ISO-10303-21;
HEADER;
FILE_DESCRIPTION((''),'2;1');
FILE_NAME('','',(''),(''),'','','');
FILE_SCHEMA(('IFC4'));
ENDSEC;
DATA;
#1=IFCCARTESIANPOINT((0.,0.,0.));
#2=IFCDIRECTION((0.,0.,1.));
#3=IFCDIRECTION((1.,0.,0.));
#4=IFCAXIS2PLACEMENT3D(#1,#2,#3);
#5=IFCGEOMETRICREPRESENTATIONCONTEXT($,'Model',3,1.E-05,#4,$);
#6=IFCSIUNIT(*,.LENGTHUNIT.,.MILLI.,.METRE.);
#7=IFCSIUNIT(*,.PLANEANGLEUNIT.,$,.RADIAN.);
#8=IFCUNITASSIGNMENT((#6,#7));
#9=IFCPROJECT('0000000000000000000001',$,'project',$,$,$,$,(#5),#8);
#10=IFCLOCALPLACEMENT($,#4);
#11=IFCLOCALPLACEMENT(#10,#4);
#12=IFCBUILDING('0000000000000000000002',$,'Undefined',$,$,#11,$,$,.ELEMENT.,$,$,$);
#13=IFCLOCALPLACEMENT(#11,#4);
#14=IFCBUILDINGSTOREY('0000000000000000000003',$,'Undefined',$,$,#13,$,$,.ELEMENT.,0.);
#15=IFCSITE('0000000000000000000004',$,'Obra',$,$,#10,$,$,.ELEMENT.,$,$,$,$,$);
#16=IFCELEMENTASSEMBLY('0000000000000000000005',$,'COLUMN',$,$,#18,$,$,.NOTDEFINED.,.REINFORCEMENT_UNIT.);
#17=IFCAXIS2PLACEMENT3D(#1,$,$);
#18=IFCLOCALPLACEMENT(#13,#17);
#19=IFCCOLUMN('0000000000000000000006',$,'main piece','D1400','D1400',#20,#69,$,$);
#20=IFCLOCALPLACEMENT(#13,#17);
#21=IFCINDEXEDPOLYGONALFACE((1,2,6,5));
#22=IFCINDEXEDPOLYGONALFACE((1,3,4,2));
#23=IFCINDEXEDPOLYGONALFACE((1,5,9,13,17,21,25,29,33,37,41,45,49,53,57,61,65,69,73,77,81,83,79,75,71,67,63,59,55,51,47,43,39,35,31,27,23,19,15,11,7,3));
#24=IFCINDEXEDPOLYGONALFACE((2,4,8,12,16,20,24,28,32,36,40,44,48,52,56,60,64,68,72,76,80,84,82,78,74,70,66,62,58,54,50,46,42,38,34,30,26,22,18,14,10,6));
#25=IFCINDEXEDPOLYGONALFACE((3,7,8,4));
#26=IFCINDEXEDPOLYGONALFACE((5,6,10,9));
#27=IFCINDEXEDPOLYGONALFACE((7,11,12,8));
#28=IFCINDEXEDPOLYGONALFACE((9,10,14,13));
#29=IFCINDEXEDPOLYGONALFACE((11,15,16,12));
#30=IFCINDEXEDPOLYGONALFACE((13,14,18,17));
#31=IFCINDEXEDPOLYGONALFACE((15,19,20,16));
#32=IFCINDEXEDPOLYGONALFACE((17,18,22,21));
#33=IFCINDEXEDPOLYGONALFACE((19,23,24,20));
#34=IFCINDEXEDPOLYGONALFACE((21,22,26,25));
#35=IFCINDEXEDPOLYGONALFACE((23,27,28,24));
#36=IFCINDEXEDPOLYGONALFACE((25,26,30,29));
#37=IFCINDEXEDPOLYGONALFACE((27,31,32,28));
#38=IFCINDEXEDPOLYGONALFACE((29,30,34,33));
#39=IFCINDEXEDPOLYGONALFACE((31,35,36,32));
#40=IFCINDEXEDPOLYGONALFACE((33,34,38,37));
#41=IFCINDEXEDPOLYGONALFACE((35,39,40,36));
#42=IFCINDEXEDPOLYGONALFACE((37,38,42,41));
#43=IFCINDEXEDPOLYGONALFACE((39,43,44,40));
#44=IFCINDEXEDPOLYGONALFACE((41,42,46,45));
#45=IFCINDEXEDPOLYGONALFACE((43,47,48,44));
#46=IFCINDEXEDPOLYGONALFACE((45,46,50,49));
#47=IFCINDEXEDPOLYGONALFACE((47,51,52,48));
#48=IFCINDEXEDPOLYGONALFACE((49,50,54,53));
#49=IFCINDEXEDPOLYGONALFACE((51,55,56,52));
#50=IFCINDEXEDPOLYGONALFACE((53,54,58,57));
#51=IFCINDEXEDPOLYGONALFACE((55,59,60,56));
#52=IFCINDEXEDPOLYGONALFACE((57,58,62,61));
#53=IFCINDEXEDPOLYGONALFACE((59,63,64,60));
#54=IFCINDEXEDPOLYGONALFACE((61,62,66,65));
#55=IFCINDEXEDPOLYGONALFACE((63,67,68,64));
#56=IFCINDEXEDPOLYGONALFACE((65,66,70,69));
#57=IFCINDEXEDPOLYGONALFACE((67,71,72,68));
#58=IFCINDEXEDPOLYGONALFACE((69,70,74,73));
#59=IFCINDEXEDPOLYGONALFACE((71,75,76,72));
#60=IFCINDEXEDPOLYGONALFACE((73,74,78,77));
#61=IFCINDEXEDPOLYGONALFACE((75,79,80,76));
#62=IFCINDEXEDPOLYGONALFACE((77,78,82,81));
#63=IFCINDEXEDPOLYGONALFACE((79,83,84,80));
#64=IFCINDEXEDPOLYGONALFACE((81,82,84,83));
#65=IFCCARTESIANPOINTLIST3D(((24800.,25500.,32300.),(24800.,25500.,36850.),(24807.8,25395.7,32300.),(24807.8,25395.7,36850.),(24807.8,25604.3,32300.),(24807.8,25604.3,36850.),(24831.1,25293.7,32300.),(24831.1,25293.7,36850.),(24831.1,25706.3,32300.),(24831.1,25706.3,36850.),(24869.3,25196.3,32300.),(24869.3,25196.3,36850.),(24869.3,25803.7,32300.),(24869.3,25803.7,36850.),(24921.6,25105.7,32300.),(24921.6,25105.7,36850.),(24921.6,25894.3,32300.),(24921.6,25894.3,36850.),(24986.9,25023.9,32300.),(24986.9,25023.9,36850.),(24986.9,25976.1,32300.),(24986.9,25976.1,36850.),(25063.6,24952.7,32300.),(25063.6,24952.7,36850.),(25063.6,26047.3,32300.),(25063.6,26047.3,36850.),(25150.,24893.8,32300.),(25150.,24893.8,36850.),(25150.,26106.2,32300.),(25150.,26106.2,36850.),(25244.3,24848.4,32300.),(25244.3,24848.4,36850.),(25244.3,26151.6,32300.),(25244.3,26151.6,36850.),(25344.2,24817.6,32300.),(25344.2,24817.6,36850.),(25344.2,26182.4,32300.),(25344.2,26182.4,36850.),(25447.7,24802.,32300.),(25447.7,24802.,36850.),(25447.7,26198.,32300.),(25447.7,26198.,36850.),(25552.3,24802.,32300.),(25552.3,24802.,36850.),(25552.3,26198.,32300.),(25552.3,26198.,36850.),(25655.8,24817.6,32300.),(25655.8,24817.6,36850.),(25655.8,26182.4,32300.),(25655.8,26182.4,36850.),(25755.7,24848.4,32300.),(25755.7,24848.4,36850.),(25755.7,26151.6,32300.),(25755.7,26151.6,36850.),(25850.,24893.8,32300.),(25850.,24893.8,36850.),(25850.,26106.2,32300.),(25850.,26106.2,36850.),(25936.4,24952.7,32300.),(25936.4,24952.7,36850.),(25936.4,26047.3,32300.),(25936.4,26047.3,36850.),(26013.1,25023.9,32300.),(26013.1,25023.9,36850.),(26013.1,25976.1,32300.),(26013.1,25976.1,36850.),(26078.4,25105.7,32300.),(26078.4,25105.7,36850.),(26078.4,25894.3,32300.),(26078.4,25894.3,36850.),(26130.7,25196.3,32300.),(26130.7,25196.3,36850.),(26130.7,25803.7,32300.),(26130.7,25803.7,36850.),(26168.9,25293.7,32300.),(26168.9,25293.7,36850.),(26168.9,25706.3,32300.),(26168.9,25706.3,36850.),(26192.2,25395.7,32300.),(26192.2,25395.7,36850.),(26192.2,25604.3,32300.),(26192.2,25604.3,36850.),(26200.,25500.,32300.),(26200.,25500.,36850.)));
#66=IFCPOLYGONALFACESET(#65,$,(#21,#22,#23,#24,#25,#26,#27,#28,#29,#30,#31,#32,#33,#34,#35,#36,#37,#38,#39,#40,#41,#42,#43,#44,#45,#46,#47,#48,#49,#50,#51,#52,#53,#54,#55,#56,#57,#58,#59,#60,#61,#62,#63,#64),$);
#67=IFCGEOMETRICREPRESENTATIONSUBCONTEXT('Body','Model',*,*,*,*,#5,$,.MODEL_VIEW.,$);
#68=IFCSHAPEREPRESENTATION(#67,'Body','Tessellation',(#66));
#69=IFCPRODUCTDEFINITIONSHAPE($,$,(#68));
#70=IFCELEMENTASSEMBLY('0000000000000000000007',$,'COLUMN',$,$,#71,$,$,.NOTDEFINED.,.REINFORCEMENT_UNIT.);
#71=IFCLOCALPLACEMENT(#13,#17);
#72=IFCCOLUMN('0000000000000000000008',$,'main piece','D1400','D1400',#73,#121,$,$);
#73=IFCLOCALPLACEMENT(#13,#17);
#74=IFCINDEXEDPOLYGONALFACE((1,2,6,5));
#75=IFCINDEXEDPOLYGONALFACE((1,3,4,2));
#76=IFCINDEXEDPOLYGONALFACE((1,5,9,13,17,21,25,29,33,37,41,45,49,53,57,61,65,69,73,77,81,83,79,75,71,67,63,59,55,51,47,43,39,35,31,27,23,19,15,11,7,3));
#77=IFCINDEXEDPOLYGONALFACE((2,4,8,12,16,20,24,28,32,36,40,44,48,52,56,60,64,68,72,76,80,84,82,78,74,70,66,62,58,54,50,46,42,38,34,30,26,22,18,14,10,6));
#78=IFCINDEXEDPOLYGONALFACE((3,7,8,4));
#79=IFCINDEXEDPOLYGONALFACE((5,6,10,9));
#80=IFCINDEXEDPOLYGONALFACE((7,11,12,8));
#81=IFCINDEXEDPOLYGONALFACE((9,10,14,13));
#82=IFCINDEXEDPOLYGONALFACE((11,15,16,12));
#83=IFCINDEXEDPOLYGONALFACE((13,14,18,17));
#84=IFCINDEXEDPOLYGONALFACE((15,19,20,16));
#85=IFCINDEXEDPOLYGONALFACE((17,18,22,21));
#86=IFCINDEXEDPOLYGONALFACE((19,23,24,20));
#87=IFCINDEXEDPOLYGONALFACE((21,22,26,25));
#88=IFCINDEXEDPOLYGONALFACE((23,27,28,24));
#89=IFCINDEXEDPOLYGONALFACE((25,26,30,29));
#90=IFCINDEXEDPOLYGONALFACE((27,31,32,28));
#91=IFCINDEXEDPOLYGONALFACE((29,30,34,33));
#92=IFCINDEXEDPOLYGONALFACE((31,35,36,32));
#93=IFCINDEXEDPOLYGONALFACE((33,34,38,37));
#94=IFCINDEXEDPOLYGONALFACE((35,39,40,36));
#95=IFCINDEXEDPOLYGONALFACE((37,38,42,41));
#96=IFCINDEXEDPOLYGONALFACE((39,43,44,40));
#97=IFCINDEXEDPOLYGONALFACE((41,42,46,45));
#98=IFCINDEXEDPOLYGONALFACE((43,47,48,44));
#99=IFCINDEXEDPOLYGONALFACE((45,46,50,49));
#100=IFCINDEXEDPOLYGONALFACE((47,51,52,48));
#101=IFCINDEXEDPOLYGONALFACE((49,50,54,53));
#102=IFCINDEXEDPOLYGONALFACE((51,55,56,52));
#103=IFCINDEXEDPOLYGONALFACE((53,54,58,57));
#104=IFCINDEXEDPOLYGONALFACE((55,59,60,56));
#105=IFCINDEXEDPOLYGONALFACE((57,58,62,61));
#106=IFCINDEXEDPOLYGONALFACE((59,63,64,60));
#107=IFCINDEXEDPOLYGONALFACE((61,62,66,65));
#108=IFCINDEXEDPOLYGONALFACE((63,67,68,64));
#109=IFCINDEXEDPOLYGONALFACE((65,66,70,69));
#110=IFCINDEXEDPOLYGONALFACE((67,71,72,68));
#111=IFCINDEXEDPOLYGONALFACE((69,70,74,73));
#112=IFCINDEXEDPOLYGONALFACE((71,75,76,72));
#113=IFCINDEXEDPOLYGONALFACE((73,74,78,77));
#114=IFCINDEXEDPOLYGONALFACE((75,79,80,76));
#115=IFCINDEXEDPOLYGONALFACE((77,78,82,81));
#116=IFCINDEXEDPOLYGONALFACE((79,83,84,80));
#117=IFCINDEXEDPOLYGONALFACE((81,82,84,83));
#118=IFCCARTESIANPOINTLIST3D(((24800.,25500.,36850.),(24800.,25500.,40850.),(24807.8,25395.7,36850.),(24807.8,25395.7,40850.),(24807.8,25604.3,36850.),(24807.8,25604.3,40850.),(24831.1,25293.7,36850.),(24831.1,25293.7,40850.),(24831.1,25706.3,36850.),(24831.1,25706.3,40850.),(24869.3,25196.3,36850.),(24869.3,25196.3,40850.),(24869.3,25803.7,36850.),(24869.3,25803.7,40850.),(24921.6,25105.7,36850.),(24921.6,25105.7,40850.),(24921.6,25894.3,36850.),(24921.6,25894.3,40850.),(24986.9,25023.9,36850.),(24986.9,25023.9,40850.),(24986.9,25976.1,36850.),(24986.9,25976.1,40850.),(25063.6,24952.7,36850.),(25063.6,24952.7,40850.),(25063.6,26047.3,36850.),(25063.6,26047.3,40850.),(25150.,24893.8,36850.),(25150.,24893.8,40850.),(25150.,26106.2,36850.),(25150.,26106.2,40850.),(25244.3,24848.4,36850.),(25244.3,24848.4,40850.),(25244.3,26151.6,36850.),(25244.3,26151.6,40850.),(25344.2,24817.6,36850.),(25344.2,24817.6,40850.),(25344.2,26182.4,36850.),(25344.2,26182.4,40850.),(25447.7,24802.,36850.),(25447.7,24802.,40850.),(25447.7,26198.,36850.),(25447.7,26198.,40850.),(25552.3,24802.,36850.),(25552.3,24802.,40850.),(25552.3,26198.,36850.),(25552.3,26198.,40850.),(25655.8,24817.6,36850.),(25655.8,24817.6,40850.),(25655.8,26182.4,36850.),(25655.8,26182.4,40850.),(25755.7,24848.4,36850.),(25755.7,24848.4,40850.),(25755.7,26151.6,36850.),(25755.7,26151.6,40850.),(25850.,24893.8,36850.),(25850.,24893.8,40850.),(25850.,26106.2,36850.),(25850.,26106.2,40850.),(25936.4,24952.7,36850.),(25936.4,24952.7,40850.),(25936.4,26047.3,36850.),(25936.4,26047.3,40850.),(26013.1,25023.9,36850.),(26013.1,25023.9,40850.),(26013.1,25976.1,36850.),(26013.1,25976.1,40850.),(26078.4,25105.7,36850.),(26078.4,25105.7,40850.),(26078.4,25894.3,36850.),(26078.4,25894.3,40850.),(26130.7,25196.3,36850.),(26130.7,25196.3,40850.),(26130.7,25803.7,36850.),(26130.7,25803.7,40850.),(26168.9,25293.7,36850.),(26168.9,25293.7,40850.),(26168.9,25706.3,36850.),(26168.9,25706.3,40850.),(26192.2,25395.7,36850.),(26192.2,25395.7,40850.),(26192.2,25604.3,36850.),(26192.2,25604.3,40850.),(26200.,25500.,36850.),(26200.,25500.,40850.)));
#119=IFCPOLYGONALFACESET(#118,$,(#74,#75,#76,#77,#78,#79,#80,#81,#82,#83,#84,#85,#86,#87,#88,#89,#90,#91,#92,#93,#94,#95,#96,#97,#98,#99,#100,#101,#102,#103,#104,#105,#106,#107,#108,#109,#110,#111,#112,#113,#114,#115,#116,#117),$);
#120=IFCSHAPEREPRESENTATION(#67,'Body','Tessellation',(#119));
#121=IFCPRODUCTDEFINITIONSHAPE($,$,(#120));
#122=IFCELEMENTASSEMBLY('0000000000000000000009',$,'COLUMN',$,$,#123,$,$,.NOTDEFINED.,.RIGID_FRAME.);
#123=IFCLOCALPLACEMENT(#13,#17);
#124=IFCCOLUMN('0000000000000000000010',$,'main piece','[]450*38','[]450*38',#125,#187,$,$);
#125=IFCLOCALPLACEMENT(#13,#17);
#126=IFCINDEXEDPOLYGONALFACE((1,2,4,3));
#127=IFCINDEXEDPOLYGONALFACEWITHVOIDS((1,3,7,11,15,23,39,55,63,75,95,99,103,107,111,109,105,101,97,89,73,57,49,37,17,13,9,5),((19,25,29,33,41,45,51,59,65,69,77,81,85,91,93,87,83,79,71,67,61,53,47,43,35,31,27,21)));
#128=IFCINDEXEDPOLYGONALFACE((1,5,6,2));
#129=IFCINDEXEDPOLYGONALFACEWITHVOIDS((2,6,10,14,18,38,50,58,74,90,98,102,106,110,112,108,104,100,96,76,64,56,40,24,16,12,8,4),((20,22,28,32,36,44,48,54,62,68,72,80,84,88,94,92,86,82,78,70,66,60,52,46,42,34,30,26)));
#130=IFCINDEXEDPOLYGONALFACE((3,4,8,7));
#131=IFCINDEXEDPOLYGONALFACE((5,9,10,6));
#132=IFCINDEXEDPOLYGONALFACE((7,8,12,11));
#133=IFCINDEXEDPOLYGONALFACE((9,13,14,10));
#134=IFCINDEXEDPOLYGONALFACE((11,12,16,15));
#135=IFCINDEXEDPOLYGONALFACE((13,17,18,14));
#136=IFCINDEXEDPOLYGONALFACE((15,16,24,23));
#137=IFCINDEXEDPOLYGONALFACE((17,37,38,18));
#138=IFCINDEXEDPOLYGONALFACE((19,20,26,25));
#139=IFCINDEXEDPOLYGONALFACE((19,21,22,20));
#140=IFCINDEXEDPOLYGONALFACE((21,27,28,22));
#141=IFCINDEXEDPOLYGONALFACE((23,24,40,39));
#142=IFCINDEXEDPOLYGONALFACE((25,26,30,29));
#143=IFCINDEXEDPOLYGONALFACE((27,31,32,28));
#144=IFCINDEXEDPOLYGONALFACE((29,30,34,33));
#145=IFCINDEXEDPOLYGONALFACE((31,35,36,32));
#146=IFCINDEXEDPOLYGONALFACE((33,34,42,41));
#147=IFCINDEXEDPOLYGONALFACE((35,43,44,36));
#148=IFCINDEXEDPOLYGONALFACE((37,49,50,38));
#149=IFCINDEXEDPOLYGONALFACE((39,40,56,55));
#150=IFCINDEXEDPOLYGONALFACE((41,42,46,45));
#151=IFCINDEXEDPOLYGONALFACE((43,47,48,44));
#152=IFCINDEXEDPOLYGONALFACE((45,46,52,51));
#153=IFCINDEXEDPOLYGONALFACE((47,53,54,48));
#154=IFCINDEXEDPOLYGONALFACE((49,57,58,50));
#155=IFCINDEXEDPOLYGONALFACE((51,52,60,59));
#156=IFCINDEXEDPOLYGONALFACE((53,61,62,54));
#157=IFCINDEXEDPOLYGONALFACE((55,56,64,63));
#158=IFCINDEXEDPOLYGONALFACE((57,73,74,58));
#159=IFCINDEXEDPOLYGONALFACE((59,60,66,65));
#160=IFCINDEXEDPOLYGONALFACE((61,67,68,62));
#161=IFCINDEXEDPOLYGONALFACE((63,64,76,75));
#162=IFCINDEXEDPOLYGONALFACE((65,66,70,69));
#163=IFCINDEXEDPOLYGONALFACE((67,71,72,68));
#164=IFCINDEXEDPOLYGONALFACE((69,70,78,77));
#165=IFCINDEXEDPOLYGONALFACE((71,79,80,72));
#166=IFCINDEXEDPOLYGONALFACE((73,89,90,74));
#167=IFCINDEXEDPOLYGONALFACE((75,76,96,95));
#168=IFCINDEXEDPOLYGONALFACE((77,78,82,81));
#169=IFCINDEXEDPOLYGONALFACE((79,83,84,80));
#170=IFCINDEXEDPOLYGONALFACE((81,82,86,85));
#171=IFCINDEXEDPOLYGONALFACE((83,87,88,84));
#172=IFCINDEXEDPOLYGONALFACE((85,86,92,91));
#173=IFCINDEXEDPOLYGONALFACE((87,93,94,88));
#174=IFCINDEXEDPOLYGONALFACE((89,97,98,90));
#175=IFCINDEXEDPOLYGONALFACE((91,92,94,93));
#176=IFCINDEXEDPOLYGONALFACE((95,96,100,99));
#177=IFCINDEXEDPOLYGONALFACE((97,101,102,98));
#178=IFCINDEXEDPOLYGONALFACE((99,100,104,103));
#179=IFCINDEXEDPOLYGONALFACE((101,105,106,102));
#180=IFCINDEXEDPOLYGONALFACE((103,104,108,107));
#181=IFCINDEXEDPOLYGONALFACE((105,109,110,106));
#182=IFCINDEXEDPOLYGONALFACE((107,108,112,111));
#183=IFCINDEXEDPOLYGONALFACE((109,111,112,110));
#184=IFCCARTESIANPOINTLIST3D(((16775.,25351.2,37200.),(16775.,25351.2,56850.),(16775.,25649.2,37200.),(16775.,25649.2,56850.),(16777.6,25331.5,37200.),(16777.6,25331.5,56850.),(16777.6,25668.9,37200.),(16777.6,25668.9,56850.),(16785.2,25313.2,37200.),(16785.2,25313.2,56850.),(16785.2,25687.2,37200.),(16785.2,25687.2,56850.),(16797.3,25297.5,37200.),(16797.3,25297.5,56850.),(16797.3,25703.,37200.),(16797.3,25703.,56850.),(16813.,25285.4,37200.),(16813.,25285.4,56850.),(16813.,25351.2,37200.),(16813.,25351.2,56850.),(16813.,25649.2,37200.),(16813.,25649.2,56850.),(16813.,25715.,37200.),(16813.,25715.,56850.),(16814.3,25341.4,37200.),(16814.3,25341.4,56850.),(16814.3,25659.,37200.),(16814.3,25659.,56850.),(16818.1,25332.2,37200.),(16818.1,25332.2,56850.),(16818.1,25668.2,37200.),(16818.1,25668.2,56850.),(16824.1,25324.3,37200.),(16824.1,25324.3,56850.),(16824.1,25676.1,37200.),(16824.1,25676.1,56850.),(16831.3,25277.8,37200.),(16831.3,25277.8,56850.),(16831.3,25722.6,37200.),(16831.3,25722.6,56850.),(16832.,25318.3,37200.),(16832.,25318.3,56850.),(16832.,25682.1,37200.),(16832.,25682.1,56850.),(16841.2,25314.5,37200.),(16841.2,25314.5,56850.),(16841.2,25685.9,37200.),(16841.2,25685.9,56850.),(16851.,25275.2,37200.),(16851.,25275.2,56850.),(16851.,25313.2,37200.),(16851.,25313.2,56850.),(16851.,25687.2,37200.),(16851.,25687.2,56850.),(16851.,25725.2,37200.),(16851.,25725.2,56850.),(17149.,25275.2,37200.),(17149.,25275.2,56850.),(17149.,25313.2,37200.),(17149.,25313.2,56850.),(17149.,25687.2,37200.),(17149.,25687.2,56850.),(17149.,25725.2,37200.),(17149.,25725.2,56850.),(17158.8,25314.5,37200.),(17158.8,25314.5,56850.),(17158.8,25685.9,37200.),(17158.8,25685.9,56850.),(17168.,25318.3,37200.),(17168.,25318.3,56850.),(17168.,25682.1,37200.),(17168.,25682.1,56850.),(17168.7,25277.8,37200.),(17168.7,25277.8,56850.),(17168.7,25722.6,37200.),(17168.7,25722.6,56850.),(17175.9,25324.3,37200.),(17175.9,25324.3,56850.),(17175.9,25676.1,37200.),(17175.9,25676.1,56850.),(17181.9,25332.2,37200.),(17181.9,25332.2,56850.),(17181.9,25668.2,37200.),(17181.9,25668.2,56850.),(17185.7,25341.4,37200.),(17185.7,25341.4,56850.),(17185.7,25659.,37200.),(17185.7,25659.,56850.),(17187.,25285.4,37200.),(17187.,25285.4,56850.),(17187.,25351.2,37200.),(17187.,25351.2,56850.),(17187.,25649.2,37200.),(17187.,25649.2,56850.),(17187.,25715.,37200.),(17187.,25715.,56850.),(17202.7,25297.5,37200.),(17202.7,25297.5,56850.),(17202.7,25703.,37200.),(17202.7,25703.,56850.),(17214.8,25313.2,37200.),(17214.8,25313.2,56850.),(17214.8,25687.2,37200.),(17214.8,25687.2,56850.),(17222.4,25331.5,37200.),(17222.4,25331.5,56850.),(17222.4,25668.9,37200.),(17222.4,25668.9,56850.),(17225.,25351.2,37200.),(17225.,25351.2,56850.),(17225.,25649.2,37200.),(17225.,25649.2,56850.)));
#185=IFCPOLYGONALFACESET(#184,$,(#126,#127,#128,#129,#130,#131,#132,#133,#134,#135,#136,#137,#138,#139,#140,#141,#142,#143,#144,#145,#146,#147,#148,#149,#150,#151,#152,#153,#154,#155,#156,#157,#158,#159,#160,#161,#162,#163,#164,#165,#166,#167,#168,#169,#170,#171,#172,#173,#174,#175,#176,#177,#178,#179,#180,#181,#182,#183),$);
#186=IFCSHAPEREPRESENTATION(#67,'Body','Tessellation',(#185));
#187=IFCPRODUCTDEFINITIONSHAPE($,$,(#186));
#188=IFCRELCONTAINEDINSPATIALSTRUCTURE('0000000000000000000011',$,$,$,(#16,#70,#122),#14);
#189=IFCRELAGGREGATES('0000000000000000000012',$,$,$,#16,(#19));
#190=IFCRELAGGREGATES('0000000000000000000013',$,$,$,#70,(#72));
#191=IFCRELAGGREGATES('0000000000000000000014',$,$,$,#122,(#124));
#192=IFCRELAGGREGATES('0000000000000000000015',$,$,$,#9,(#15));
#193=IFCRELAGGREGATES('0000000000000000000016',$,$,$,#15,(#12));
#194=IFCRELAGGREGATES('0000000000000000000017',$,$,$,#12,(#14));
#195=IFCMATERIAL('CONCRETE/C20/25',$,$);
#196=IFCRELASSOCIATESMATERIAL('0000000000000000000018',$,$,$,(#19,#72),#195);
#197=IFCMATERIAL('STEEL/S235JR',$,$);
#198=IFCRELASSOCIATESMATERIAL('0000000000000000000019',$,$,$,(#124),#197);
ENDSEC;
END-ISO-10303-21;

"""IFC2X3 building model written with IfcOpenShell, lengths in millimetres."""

from ifc_helpers import new_model, si_unit, frame, origin_with_axes, origin_2d_with_axis, place, context, subcontext, project, spatial, hollow_rectangle, circle, extrude, material, element, aggregate, save


model = new_model("IFC2X3")

# Units and contexts
model_context = context("Model", 3, precision=1e-05, world=origin_with_axes())
body_context = subcontext(model_context, "Body", "Model", "MODEL_VIEW")
ifc_project = project(units=[si_unit("LENGTHUNIT", "METRE", prefix="MILLI"), si_unit("PLANEANGLEUNIT", "RADIAN")], contexts=[model_context])

# Site, building, storey
site_placement = place(None, origin_with_axes())
site = spatial("IfcSite", under=ifc_project, at=site_placement, Name="Obra", CompositionType="ELEMENT")
building_placement = place(site_placement, origin_with_axes())
building = spatial("IfcBuilding", under=site, at=building_placement, Name="Undefined", CompositionType="ELEMENT")
storey_placement = place(building_placement, origin_with_axes())
storey = spatial("IfcBuildingStorey", under=building, at=storey_placement, Name="Undefined", CompositionType="ELEMENT", Elevation=0.0)

# Element assemblies, columns
assembly_1_placement = place(storey_placement, origin_with_axes())
assembly_1 = element("IfcElementAssembly", 1, at=assembly_1_placement, inside=storey, Name="COLUMN", AssemblyPlace="NOTDEFINED", PredefinedType="REINFORCEMENT_UNIT")
ifc_material_1 = material(Name="CONCRETE/C20/25")
column_1_placement = place(assembly_1_placement, frame((25500.0, 25500.0, 32300.0), z_axis=(0.0, 0.0, 1.0), x_axis=(0.0, 1.0, 0.0)))
column_1 = element("IfcColumn", 2, at=column_1_placement, material=ifc_material_1, Name="main piece", Description="D1400", ObjectType="D1400", context=body_context, shape_type="SweptSolid", body=[
    extrude(circle(Radius=700.0, at=origin_2d_with_axis()), frame((0.0, 0.0, 4550.0), z_axis=(0.0, 0.0, -1.0), x_axis=(0.0, 1.0, 0.0)), (0.0, 0.0, 1.0), 4550.0),
])
aggregate(assembly_1, [column_1])
assembly_2_placement = place(storey_placement, origin_with_axes())
assembly_2 = element("IfcElementAssembly", 3, at=assembly_2_placement, inside=storey, Name="COLUMN", AssemblyPlace="NOTDEFINED", PredefinedType="REINFORCEMENT_UNIT")
column_2_placement = place(assembly_2_placement, frame((25500.0, 25500.0, 36850.0), z_axis=(0.0, 0.0, 1.0), x_axis=(0.0, 1.0, 0.0)))
column_2 = element("IfcColumn", 4, at=column_2_placement, material=ifc_material_1, Name="main piece", Description="D1400", ObjectType="D1400", context=body_context, shape_type="SweptSolid", body=[
    extrude(circle(Radius=700.0, at=origin_2d_with_axis()), frame((0.0, 0.0, 4000.0), z_axis=(0.0, 0.0, -1.0), x_axis=(0.0, 1.0, 0.0)), (0.0, 0.0, 1.0), 4000.0),
])
aggregate(assembly_2, [column_2])
assembly_3_placement = place(storey_placement, origin_with_axes())
assembly_3 = element("IfcElementAssembly", 5, at=assembly_3_placement, inside=storey, Name="COLUMN", AssemblyPlace="NOTDEFINED", PredefinedType="RIGID_FRAME")
ifc_material_2 = material(Name="STEEL/S235JR")
column_3_placement = place(assembly_3_placement, frame((17000.0, 25500.2, 37200.0), z_axis=(0.0, 0.0, 1.0), x_axis=(0.0, 1.0, 0.0)))
column_3 = element("IfcColumn", 6, at=column_3_placement, material=ifc_material_2, Name="main piece", Description="[]450*38", ObjectType="[]450*38", context=body_context, shape_type="SweptSolid", body=[
    extrude(hollow_rectangle(XDim=450.0, YDim=450.0, WallThickness=38.0, InnerFilletRadius=38.0, OuterFilletRadius=76.0, at=origin_2d_with_axis()), frame((0.0, 0.0, 19650.0), z_axis=(0.0, 0.0, -1.0), x_axis=(0.0, 1.0, 0.0)), (0.0, 0.0, 1.0), 19650.0),
])
aggregate(assembly_3, [column_3])

save(model, "model.ifc")
